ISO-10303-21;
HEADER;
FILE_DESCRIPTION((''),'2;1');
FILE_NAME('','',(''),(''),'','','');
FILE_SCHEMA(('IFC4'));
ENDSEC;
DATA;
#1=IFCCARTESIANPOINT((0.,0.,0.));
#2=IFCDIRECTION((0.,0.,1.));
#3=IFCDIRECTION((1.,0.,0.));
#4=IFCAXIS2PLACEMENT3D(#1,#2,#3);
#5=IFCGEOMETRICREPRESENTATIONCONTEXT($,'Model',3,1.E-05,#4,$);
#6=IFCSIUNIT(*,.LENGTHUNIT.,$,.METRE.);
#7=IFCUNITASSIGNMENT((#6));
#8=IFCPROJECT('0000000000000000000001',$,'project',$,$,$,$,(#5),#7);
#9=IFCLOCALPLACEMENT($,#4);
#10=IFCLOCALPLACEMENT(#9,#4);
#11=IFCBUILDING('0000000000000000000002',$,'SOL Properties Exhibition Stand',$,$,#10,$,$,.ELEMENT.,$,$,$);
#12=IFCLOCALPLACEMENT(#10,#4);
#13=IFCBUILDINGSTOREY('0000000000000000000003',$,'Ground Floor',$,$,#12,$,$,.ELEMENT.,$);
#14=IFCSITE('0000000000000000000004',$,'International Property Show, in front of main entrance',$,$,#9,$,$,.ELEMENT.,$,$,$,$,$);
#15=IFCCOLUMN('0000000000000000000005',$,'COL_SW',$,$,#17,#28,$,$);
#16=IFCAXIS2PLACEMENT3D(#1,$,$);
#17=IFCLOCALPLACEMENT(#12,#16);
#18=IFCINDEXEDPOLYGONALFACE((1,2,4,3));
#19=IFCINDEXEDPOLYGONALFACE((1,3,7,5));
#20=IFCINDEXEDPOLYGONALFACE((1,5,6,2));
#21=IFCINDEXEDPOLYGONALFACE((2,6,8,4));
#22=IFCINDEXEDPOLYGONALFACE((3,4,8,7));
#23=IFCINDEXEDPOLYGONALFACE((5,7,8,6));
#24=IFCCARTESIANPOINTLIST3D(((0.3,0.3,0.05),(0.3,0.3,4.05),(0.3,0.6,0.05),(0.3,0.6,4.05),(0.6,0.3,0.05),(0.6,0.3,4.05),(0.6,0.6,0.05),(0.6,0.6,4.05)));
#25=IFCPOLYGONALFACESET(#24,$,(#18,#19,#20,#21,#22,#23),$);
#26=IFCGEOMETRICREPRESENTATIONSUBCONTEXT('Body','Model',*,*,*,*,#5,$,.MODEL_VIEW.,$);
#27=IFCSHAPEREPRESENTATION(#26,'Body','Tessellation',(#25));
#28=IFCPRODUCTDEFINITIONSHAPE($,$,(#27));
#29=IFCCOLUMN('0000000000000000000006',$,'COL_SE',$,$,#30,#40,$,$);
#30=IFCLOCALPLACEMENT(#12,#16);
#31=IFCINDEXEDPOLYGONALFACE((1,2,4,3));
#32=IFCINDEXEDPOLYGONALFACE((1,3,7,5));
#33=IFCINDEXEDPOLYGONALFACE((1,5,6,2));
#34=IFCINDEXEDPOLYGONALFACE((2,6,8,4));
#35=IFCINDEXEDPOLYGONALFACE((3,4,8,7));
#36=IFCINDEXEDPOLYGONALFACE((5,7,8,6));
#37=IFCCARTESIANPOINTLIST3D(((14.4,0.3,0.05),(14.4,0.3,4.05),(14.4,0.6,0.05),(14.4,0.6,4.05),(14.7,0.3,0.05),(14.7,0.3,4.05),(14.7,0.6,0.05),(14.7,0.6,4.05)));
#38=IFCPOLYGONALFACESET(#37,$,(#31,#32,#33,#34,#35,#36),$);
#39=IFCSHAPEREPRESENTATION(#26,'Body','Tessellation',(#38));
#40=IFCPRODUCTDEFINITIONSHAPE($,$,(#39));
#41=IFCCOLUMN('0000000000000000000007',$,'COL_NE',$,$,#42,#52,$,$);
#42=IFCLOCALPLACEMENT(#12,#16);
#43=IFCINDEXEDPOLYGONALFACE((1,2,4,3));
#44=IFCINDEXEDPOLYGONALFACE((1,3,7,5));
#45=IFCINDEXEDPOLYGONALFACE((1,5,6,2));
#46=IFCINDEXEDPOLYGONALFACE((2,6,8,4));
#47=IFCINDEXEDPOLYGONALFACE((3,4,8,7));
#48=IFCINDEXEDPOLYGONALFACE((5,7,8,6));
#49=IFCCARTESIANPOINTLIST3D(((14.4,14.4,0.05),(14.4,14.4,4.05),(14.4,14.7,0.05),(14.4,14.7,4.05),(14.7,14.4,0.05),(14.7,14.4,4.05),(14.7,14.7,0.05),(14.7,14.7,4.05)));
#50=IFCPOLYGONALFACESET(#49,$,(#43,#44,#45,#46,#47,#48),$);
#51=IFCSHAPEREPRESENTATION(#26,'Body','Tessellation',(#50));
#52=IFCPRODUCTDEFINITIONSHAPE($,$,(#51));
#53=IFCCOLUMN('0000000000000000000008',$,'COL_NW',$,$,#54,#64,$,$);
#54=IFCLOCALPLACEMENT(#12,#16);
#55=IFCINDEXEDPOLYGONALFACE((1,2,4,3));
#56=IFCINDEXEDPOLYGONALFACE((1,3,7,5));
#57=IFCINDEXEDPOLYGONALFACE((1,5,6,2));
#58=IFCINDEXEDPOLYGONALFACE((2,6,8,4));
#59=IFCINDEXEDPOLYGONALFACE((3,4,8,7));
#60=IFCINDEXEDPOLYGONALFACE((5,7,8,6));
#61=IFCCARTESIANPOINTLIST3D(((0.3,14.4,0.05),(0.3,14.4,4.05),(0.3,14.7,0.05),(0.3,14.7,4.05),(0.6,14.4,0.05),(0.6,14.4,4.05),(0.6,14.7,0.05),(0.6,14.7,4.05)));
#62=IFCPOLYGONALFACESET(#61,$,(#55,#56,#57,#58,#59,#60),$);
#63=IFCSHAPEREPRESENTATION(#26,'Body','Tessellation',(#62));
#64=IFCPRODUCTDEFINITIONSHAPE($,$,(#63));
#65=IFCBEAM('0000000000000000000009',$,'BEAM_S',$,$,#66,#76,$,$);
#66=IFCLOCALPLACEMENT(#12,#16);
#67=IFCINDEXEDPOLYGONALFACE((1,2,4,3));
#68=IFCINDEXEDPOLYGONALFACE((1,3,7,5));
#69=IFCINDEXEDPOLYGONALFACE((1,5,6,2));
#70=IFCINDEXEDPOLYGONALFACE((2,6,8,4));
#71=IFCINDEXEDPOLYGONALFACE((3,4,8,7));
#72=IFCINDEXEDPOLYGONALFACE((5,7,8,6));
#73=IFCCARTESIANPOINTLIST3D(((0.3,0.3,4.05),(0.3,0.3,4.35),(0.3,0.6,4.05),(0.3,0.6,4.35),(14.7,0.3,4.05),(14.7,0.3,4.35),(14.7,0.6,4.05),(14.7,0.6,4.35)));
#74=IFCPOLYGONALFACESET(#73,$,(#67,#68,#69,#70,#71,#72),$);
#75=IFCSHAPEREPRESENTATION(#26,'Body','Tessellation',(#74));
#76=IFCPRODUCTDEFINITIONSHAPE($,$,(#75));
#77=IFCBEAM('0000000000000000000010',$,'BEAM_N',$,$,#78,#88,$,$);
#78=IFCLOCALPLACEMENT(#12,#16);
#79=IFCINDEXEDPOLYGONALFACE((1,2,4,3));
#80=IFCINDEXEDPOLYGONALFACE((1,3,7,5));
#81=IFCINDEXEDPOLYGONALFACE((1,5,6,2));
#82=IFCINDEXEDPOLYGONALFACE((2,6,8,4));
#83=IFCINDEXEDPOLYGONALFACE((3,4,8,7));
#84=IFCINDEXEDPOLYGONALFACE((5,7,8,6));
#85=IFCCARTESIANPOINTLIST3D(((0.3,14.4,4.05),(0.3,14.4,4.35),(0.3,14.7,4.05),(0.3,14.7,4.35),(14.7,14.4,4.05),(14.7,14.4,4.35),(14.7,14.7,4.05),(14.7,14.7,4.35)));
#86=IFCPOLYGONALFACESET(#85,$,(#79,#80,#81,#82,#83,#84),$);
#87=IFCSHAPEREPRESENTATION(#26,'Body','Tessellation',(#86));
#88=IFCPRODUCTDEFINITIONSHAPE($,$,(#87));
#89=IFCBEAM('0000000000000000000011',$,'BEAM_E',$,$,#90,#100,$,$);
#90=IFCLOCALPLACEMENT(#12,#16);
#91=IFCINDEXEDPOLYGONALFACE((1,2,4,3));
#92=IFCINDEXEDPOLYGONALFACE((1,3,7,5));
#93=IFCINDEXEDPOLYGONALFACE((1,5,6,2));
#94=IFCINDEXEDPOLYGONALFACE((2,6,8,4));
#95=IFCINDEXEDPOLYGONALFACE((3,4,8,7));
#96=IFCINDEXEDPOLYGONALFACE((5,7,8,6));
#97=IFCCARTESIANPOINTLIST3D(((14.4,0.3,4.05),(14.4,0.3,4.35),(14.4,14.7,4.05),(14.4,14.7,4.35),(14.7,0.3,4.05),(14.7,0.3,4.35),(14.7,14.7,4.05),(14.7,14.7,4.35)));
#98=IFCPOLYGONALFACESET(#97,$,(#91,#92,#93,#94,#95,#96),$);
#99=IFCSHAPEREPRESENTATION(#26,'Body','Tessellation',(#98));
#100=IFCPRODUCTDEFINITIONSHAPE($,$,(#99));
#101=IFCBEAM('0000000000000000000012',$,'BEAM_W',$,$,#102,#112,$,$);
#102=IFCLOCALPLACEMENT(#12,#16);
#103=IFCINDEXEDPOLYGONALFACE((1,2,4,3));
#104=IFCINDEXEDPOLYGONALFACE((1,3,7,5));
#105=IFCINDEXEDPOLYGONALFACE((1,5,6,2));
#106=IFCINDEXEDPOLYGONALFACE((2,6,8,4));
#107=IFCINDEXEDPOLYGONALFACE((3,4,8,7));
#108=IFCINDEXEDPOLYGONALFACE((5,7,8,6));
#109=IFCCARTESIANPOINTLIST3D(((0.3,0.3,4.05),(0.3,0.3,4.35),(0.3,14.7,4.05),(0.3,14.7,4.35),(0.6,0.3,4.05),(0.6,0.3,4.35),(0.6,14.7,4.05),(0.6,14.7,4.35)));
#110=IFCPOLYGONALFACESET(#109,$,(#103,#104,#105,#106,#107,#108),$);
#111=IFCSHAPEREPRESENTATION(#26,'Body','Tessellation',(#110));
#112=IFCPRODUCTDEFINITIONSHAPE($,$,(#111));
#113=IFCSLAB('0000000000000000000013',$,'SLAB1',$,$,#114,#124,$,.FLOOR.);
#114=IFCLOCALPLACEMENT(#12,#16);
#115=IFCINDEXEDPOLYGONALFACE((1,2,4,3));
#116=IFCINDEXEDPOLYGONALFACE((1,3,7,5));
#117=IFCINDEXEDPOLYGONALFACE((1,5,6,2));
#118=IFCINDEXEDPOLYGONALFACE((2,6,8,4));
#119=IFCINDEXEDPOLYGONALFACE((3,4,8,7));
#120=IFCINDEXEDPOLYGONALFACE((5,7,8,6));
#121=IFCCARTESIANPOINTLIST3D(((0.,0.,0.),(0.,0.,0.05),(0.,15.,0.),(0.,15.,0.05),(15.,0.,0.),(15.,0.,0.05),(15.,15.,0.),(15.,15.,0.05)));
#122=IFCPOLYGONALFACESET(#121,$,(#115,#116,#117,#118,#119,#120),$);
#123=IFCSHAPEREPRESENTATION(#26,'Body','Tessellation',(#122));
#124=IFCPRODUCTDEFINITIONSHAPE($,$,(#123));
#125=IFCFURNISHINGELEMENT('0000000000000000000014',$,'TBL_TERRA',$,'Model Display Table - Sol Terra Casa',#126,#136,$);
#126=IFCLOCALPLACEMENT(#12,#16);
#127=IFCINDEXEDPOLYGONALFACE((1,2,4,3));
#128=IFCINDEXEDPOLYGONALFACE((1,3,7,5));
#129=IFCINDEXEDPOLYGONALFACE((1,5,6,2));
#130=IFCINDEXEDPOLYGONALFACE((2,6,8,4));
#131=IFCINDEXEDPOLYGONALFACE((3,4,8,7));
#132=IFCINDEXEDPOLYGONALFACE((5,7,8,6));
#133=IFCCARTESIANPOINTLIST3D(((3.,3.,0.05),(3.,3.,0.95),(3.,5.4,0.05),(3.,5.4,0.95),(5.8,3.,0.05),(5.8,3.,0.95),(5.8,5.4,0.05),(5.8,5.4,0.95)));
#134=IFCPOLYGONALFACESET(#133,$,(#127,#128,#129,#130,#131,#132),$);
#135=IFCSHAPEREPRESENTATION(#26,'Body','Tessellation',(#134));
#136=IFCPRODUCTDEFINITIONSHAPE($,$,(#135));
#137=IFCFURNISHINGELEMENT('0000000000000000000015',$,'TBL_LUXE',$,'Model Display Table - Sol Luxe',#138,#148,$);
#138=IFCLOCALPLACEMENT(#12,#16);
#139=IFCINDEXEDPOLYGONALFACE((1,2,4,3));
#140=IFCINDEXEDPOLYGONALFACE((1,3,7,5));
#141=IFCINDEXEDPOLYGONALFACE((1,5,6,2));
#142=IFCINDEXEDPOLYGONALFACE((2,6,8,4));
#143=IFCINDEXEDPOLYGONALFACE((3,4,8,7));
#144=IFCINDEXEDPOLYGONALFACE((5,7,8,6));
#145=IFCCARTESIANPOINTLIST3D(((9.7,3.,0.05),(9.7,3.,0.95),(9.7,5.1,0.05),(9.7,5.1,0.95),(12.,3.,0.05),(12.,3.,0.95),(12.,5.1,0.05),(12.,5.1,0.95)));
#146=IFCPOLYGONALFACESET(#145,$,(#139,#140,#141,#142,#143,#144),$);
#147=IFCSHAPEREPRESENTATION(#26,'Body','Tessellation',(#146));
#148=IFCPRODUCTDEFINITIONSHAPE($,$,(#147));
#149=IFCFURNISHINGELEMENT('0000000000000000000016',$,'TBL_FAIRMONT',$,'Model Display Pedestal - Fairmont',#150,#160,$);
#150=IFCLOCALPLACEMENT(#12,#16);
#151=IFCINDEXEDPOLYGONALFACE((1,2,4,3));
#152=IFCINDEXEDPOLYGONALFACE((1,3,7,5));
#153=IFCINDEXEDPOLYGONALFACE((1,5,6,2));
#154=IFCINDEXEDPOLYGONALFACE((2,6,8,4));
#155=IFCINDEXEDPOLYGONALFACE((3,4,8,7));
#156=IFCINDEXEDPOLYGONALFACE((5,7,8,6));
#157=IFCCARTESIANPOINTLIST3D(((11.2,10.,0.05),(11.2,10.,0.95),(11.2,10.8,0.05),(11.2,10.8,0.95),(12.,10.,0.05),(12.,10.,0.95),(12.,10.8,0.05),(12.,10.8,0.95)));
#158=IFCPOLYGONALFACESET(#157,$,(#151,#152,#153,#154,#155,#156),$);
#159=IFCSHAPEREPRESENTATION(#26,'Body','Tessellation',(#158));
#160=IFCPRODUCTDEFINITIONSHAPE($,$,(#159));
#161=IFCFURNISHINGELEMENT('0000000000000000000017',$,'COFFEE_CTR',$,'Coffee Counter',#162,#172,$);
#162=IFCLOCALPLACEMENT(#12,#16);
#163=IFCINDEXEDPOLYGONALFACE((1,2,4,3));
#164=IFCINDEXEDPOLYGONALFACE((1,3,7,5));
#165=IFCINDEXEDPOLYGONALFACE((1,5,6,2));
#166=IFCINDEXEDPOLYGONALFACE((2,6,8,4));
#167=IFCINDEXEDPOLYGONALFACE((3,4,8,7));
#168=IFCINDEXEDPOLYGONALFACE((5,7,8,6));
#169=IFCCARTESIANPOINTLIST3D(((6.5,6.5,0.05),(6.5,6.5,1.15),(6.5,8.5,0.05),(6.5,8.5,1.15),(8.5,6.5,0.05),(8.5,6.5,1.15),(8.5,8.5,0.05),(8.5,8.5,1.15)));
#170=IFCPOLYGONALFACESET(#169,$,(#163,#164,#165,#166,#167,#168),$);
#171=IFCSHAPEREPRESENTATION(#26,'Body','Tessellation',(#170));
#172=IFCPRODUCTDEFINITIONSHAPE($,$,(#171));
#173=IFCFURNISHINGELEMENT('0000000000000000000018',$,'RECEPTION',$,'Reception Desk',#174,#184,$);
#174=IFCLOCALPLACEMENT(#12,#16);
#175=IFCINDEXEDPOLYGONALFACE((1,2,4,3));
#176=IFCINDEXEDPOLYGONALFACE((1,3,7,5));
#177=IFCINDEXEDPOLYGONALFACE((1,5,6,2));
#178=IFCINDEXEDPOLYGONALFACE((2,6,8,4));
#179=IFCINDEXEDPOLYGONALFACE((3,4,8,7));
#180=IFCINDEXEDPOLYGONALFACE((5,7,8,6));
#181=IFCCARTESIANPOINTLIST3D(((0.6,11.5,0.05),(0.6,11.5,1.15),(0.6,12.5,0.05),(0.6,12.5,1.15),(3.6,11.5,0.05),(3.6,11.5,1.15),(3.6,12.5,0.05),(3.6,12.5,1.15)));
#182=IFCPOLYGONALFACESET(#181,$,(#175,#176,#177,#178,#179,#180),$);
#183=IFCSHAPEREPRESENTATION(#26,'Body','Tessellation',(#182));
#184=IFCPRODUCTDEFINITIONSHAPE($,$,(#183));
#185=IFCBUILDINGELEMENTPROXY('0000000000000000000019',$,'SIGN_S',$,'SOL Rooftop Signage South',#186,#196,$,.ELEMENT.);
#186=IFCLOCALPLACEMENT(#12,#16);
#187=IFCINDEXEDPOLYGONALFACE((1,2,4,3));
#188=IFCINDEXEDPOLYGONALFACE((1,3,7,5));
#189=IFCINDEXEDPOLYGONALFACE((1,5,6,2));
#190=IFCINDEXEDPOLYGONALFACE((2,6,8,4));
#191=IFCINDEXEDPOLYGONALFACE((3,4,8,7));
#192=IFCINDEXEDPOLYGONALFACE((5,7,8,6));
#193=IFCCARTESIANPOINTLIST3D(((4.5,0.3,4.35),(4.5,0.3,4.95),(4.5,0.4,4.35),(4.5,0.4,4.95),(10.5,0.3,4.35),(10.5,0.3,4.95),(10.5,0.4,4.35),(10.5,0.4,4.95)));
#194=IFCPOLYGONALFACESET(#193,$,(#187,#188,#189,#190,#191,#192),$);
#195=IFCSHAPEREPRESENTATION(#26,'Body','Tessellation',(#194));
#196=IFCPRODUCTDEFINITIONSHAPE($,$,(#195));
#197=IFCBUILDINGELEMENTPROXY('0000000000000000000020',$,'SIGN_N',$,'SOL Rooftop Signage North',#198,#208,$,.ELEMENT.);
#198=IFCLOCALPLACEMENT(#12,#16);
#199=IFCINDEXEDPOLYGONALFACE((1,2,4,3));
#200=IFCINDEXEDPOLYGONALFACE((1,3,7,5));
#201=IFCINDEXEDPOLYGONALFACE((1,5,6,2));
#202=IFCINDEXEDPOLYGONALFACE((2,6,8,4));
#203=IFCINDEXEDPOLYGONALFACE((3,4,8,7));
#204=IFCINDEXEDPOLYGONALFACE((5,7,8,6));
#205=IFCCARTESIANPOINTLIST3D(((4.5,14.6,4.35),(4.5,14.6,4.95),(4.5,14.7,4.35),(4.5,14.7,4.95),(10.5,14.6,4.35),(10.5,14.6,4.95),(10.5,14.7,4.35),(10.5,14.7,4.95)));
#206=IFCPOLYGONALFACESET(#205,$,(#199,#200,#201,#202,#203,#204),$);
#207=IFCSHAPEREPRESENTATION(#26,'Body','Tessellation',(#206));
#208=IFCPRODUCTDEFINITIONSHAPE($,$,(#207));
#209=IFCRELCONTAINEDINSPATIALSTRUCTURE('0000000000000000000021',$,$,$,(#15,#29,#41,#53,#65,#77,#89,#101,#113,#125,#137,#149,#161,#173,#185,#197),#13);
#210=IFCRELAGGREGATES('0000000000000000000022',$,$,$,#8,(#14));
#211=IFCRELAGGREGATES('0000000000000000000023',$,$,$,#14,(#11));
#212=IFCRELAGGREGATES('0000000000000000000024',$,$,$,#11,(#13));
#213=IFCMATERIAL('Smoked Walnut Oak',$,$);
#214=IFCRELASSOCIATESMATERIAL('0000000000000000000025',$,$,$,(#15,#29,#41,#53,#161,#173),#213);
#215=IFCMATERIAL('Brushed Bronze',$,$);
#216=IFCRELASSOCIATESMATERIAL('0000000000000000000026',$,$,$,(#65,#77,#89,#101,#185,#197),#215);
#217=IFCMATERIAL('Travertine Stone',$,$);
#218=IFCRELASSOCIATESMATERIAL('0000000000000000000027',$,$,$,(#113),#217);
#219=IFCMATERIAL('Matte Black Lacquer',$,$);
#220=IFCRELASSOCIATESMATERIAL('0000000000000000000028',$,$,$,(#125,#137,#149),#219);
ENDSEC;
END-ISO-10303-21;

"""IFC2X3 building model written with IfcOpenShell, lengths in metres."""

from ifc_helpers import new_model, si_unit, frame, frame_2d, origin, origin_with_axes, place, context, subcontext, project, spatial, rectangle, extrude, material, element, save


model = new_model("IFC2X3")

# Units and contexts
model_context = context("Model", 3, precision=1e-05, world=origin_with_axes())
body_context = subcontext(model_context, "Body", "Model", "MODEL_VIEW")
ifc_project = project(units=[si_unit("LENGTHUNIT", "METRE")], contexts=[model_context])

# Site, building, storey
site_placement = place(None, origin_with_axes())
site = spatial("IfcSite", under=ifc_project, at=site_placement, Name="International Property Show, in front of main entrance", CompositionType="ELEMENT")
building_placement = place(site_placement, origin_with_axes())
building = spatial("IfcBuilding", under=site, at=building_placement, Name="SOL Properties Exhibition Stand", CompositionType="ELEMENT")
storey_placement = place(building_placement, origin_with_axes())
storey = spatial("IfcBuildingStorey", under=building, at=storey_placement, Name="Ground Floor", CompositionType="ELEMENT")

# Columns
ifc_material_1 = material(Name="Smoked Walnut Oak")
for number, where, z_axis, x_axis, name in (
    (1, (0.3, 0.3, 0.05), (0.0, 0.0, 1.0), (1.0, 0.0, 0.0), "COL_SW"),
    (2, (14.4, 0.3, 0.05), (0.0, 0.0, 1.0), (1.0, 0.0, 0.0), "COL_SE"),
    (3, (14.4, 14.4, 0.05), (0.0, 0.0, 1.0), (1.0, 0.0, 0.0), "COL_NE"),
    (4, (0.3, 14.4, 0.05), (0.0, 0.0, 1.0), (1.0, 0.0, 0.0), "COL_NW"),
):
    element("IfcColumn", number, at=place(storey_placement, frame(where, z_axis=z_axis, x_axis=x_axis)), inside=storey, material=ifc_material_1, Name=name, context=body_context, shape_type="SweptSolid", body=[
        extrude(rectangle(XDim=0.3, YDim=0.3, at=frame_2d((0.15, 0.15))), origin(), (0.0, 0.0, 1.0), 4.0),
    ])

# Beams
ifc_material_2 = material(Name="Brushed Bronze")
for number, where, z_axis, x_axis, name in (
    (5, (0.3, 0.3, 4.05), (0.0, 0.0, 1.0), (1.0, 0.0, 0.0), "BEAM_S"),
    (6, (0.3, 14.4, 4.05), (0.0, 0.0, 1.0), (1.0, 0.0, 0.0), "BEAM_N"),
):
    element("IfcBeam", number, at=place(storey_placement, frame(where, z_axis=z_axis, x_axis=x_axis)), inside=storey, material=ifc_material_2, Name=name, context=body_context, shape_type="SweptSolid", body=[
        extrude(rectangle(XDim=14.4, YDim=0.3, at=frame_2d((7.2, 0.15))), origin(), (0.0, 0.0, 1.0), 0.3),
    ])
for number, where, z_axis, x_axis, name in (
    (7, (14.4, 0.3, 4.05), (0.0, 0.0, 1.0), (1.0, 0.0, 0.0), "BEAM_E"),
    (8, (0.3, 0.3, 4.05), (0.0, 0.0, 1.0), (1.0, 0.0, 0.0), "BEAM_W"),
):
    element("IfcBeam", number, at=place(storey_placement, frame(where, z_axis=z_axis, x_axis=x_axis)), inside=storey, material=ifc_material_2, Name=name, context=body_context, shape_type="SweptSolid", body=[
        extrude(rectangle(XDim=0.3, YDim=14.4, at=frame_2d((0.15, 7.2))), origin(), (0.0, 0.0, 1.0), 0.3),
    ])

# Slab
ifc_material_3 = material(Name="Travertine Stone")
slab_placement = place(storey_placement, origin_with_axes())
element("IfcSlab", 9, at=slab_placement, inside=storey, material=ifc_material_3, Name="SLAB1", PredefinedType="FLOOR", context=body_context, shape_type="SweptSolid", body=[
    extrude(rectangle(XDim=15.0, YDim=15.0, at=frame_2d((7.5, 7.5))), origin(), (0.0, 0.0, 1.0), 0.05),
])

# Furnishing elements
ifc_material_4 = material(Name="Matte Black Lacquer")
furnishing_1_placement = place(storey_placement, frame((3.0, 3.0, 0.05), z_axis=(0.0, 0.0, 1.0), x_axis=(1.0, 0.0, 0.0)))
element("IfcFurnishingElement", 10, at=furnishing_1_placement, inside=storey, material=ifc_material_4, Name="TBL_TERRA", ObjectType="Model Display Table - Sol Terra Casa", context=body_context, shape_type="SweptSolid", body=[
    extrude(rectangle(XDim=2.8, YDim=2.4, at=frame_2d((1.4, 1.2))), origin(), (0.0, 0.0, 1.0), 0.9),
])
furnishing_2_placement = place(storey_placement, frame((9.7, 3.0, 0.05), z_axis=(0.0, 0.0, 1.0), x_axis=(1.0, 0.0, 0.0)))
element("IfcFurnishingElement", 11, at=furnishing_2_placement, inside=storey, material=ifc_material_4, Name="TBL_LUXE", ObjectType="Model Display Table - Sol Luxe", context=body_context, shape_type="SweptSolid", body=[
    extrude(rectangle(XDim=2.3, YDim=2.1, at=frame_2d((1.15, 1.05))), origin(), (0.0, 0.0, 1.0), 0.9),
])
furnishing_3_placement = place(storey_placement, frame((11.2, 10.0, 0.05), z_axis=(0.0, 0.0, 1.0), x_axis=(1.0, 0.0, 0.0)))
element("IfcFurnishingElement", 12, at=furnishing_3_placement, inside=storey, material=ifc_material_4, Name="TBL_FAIRMONT", ObjectType="Model Display Pedestal - Fairmont", context=body_context, shape_type="SweptSolid", body=[
    extrude(rectangle(XDim=0.8, YDim=0.8, at=frame_2d((0.4, 0.4))), origin(), (0.0, 0.0, 1.0), 0.9),
])
furnishing_4_placement = place(storey_placement, frame((6.5, 6.5, 0.05), z_axis=(0.0, 0.0, 1.0), x_axis=(1.0, 0.0, 0.0)))
element("IfcFurnishingElement", 13, at=furnishing_4_placement, inside=storey, material=ifc_material_1, Name="COFFEE_CTR", ObjectType="Coffee Counter", context=body_context, shape_type="SweptSolid", body=[
    extrude(rectangle(XDim=2.0, YDim=2.0, at=frame_2d((1.0, 1.0))), origin(), (0.0, 0.0, 1.0), 1.1),
])
furnishing_5_placement = place(storey_placement, frame((0.6, 11.5, 0.05), z_axis=(0.0, 0.0, 1.0), x_axis=(1.0, 0.0, 0.0)))
element("IfcFurnishingElement", 14, at=furnishing_5_placement, inside=storey, material=ifc_material_1, Name="RECEPTION", ObjectType="Reception Desk", context=body_context, shape_type="SweptSolid", body=[
    extrude(rectangle(XDim=3.0, YDim=1.0, at=frame_2d((1.5, 0.5))), origin(), (0.0, 0.0, 1.0), 1.1),
])

# Building element proxies
proxy_1_placement = place(storey_placement, frame((4.5, 0.3, 4.35), z_axis=(0.0, 0.0, 1.0), x_axis=(1.0, 0.0, 0.0)))
element("IfcBuildingElementProxy", 15, at=proxy_1_placement, inside=storey, material=ifc_material_2, Name="SIGN_S", ObjectType="SOL Rooftop Signage South", CompositionType="ELEMENT", context=body_context, shape_type="SweptSolid", body=[
    extrude(rectangle(XDim=6.0, YDim=0.1, at=frame_2d((3.0, 0.05))), origin(), (0.0, 0.0, 1.0), 0.6),
])
proxy_2_placement = place(storey_placement, frame((4.5, 14.6, 4.35), z_axis=(0.0, 0.0, 1.0), x_axis=(1.0, 0.0, 0.0)))
element("IfcBuildingElementProxy", 16, at=proxy_2_placement, inside=storey, material=ifc_material_2, Name="SIGN_N", ObjectType="SOL Rooftop Signage North", CompositionType="ELEMENT", context=body_context, shape_type="SweptSolid", body=[
    extrude(rectangle(XDim=6.0, YDim=0.1, at=frame_2d((3.0, 0.05))), origin(), (0.0, 0.0, 1.0), 0.6),
])

save(model, "model.ifc")
